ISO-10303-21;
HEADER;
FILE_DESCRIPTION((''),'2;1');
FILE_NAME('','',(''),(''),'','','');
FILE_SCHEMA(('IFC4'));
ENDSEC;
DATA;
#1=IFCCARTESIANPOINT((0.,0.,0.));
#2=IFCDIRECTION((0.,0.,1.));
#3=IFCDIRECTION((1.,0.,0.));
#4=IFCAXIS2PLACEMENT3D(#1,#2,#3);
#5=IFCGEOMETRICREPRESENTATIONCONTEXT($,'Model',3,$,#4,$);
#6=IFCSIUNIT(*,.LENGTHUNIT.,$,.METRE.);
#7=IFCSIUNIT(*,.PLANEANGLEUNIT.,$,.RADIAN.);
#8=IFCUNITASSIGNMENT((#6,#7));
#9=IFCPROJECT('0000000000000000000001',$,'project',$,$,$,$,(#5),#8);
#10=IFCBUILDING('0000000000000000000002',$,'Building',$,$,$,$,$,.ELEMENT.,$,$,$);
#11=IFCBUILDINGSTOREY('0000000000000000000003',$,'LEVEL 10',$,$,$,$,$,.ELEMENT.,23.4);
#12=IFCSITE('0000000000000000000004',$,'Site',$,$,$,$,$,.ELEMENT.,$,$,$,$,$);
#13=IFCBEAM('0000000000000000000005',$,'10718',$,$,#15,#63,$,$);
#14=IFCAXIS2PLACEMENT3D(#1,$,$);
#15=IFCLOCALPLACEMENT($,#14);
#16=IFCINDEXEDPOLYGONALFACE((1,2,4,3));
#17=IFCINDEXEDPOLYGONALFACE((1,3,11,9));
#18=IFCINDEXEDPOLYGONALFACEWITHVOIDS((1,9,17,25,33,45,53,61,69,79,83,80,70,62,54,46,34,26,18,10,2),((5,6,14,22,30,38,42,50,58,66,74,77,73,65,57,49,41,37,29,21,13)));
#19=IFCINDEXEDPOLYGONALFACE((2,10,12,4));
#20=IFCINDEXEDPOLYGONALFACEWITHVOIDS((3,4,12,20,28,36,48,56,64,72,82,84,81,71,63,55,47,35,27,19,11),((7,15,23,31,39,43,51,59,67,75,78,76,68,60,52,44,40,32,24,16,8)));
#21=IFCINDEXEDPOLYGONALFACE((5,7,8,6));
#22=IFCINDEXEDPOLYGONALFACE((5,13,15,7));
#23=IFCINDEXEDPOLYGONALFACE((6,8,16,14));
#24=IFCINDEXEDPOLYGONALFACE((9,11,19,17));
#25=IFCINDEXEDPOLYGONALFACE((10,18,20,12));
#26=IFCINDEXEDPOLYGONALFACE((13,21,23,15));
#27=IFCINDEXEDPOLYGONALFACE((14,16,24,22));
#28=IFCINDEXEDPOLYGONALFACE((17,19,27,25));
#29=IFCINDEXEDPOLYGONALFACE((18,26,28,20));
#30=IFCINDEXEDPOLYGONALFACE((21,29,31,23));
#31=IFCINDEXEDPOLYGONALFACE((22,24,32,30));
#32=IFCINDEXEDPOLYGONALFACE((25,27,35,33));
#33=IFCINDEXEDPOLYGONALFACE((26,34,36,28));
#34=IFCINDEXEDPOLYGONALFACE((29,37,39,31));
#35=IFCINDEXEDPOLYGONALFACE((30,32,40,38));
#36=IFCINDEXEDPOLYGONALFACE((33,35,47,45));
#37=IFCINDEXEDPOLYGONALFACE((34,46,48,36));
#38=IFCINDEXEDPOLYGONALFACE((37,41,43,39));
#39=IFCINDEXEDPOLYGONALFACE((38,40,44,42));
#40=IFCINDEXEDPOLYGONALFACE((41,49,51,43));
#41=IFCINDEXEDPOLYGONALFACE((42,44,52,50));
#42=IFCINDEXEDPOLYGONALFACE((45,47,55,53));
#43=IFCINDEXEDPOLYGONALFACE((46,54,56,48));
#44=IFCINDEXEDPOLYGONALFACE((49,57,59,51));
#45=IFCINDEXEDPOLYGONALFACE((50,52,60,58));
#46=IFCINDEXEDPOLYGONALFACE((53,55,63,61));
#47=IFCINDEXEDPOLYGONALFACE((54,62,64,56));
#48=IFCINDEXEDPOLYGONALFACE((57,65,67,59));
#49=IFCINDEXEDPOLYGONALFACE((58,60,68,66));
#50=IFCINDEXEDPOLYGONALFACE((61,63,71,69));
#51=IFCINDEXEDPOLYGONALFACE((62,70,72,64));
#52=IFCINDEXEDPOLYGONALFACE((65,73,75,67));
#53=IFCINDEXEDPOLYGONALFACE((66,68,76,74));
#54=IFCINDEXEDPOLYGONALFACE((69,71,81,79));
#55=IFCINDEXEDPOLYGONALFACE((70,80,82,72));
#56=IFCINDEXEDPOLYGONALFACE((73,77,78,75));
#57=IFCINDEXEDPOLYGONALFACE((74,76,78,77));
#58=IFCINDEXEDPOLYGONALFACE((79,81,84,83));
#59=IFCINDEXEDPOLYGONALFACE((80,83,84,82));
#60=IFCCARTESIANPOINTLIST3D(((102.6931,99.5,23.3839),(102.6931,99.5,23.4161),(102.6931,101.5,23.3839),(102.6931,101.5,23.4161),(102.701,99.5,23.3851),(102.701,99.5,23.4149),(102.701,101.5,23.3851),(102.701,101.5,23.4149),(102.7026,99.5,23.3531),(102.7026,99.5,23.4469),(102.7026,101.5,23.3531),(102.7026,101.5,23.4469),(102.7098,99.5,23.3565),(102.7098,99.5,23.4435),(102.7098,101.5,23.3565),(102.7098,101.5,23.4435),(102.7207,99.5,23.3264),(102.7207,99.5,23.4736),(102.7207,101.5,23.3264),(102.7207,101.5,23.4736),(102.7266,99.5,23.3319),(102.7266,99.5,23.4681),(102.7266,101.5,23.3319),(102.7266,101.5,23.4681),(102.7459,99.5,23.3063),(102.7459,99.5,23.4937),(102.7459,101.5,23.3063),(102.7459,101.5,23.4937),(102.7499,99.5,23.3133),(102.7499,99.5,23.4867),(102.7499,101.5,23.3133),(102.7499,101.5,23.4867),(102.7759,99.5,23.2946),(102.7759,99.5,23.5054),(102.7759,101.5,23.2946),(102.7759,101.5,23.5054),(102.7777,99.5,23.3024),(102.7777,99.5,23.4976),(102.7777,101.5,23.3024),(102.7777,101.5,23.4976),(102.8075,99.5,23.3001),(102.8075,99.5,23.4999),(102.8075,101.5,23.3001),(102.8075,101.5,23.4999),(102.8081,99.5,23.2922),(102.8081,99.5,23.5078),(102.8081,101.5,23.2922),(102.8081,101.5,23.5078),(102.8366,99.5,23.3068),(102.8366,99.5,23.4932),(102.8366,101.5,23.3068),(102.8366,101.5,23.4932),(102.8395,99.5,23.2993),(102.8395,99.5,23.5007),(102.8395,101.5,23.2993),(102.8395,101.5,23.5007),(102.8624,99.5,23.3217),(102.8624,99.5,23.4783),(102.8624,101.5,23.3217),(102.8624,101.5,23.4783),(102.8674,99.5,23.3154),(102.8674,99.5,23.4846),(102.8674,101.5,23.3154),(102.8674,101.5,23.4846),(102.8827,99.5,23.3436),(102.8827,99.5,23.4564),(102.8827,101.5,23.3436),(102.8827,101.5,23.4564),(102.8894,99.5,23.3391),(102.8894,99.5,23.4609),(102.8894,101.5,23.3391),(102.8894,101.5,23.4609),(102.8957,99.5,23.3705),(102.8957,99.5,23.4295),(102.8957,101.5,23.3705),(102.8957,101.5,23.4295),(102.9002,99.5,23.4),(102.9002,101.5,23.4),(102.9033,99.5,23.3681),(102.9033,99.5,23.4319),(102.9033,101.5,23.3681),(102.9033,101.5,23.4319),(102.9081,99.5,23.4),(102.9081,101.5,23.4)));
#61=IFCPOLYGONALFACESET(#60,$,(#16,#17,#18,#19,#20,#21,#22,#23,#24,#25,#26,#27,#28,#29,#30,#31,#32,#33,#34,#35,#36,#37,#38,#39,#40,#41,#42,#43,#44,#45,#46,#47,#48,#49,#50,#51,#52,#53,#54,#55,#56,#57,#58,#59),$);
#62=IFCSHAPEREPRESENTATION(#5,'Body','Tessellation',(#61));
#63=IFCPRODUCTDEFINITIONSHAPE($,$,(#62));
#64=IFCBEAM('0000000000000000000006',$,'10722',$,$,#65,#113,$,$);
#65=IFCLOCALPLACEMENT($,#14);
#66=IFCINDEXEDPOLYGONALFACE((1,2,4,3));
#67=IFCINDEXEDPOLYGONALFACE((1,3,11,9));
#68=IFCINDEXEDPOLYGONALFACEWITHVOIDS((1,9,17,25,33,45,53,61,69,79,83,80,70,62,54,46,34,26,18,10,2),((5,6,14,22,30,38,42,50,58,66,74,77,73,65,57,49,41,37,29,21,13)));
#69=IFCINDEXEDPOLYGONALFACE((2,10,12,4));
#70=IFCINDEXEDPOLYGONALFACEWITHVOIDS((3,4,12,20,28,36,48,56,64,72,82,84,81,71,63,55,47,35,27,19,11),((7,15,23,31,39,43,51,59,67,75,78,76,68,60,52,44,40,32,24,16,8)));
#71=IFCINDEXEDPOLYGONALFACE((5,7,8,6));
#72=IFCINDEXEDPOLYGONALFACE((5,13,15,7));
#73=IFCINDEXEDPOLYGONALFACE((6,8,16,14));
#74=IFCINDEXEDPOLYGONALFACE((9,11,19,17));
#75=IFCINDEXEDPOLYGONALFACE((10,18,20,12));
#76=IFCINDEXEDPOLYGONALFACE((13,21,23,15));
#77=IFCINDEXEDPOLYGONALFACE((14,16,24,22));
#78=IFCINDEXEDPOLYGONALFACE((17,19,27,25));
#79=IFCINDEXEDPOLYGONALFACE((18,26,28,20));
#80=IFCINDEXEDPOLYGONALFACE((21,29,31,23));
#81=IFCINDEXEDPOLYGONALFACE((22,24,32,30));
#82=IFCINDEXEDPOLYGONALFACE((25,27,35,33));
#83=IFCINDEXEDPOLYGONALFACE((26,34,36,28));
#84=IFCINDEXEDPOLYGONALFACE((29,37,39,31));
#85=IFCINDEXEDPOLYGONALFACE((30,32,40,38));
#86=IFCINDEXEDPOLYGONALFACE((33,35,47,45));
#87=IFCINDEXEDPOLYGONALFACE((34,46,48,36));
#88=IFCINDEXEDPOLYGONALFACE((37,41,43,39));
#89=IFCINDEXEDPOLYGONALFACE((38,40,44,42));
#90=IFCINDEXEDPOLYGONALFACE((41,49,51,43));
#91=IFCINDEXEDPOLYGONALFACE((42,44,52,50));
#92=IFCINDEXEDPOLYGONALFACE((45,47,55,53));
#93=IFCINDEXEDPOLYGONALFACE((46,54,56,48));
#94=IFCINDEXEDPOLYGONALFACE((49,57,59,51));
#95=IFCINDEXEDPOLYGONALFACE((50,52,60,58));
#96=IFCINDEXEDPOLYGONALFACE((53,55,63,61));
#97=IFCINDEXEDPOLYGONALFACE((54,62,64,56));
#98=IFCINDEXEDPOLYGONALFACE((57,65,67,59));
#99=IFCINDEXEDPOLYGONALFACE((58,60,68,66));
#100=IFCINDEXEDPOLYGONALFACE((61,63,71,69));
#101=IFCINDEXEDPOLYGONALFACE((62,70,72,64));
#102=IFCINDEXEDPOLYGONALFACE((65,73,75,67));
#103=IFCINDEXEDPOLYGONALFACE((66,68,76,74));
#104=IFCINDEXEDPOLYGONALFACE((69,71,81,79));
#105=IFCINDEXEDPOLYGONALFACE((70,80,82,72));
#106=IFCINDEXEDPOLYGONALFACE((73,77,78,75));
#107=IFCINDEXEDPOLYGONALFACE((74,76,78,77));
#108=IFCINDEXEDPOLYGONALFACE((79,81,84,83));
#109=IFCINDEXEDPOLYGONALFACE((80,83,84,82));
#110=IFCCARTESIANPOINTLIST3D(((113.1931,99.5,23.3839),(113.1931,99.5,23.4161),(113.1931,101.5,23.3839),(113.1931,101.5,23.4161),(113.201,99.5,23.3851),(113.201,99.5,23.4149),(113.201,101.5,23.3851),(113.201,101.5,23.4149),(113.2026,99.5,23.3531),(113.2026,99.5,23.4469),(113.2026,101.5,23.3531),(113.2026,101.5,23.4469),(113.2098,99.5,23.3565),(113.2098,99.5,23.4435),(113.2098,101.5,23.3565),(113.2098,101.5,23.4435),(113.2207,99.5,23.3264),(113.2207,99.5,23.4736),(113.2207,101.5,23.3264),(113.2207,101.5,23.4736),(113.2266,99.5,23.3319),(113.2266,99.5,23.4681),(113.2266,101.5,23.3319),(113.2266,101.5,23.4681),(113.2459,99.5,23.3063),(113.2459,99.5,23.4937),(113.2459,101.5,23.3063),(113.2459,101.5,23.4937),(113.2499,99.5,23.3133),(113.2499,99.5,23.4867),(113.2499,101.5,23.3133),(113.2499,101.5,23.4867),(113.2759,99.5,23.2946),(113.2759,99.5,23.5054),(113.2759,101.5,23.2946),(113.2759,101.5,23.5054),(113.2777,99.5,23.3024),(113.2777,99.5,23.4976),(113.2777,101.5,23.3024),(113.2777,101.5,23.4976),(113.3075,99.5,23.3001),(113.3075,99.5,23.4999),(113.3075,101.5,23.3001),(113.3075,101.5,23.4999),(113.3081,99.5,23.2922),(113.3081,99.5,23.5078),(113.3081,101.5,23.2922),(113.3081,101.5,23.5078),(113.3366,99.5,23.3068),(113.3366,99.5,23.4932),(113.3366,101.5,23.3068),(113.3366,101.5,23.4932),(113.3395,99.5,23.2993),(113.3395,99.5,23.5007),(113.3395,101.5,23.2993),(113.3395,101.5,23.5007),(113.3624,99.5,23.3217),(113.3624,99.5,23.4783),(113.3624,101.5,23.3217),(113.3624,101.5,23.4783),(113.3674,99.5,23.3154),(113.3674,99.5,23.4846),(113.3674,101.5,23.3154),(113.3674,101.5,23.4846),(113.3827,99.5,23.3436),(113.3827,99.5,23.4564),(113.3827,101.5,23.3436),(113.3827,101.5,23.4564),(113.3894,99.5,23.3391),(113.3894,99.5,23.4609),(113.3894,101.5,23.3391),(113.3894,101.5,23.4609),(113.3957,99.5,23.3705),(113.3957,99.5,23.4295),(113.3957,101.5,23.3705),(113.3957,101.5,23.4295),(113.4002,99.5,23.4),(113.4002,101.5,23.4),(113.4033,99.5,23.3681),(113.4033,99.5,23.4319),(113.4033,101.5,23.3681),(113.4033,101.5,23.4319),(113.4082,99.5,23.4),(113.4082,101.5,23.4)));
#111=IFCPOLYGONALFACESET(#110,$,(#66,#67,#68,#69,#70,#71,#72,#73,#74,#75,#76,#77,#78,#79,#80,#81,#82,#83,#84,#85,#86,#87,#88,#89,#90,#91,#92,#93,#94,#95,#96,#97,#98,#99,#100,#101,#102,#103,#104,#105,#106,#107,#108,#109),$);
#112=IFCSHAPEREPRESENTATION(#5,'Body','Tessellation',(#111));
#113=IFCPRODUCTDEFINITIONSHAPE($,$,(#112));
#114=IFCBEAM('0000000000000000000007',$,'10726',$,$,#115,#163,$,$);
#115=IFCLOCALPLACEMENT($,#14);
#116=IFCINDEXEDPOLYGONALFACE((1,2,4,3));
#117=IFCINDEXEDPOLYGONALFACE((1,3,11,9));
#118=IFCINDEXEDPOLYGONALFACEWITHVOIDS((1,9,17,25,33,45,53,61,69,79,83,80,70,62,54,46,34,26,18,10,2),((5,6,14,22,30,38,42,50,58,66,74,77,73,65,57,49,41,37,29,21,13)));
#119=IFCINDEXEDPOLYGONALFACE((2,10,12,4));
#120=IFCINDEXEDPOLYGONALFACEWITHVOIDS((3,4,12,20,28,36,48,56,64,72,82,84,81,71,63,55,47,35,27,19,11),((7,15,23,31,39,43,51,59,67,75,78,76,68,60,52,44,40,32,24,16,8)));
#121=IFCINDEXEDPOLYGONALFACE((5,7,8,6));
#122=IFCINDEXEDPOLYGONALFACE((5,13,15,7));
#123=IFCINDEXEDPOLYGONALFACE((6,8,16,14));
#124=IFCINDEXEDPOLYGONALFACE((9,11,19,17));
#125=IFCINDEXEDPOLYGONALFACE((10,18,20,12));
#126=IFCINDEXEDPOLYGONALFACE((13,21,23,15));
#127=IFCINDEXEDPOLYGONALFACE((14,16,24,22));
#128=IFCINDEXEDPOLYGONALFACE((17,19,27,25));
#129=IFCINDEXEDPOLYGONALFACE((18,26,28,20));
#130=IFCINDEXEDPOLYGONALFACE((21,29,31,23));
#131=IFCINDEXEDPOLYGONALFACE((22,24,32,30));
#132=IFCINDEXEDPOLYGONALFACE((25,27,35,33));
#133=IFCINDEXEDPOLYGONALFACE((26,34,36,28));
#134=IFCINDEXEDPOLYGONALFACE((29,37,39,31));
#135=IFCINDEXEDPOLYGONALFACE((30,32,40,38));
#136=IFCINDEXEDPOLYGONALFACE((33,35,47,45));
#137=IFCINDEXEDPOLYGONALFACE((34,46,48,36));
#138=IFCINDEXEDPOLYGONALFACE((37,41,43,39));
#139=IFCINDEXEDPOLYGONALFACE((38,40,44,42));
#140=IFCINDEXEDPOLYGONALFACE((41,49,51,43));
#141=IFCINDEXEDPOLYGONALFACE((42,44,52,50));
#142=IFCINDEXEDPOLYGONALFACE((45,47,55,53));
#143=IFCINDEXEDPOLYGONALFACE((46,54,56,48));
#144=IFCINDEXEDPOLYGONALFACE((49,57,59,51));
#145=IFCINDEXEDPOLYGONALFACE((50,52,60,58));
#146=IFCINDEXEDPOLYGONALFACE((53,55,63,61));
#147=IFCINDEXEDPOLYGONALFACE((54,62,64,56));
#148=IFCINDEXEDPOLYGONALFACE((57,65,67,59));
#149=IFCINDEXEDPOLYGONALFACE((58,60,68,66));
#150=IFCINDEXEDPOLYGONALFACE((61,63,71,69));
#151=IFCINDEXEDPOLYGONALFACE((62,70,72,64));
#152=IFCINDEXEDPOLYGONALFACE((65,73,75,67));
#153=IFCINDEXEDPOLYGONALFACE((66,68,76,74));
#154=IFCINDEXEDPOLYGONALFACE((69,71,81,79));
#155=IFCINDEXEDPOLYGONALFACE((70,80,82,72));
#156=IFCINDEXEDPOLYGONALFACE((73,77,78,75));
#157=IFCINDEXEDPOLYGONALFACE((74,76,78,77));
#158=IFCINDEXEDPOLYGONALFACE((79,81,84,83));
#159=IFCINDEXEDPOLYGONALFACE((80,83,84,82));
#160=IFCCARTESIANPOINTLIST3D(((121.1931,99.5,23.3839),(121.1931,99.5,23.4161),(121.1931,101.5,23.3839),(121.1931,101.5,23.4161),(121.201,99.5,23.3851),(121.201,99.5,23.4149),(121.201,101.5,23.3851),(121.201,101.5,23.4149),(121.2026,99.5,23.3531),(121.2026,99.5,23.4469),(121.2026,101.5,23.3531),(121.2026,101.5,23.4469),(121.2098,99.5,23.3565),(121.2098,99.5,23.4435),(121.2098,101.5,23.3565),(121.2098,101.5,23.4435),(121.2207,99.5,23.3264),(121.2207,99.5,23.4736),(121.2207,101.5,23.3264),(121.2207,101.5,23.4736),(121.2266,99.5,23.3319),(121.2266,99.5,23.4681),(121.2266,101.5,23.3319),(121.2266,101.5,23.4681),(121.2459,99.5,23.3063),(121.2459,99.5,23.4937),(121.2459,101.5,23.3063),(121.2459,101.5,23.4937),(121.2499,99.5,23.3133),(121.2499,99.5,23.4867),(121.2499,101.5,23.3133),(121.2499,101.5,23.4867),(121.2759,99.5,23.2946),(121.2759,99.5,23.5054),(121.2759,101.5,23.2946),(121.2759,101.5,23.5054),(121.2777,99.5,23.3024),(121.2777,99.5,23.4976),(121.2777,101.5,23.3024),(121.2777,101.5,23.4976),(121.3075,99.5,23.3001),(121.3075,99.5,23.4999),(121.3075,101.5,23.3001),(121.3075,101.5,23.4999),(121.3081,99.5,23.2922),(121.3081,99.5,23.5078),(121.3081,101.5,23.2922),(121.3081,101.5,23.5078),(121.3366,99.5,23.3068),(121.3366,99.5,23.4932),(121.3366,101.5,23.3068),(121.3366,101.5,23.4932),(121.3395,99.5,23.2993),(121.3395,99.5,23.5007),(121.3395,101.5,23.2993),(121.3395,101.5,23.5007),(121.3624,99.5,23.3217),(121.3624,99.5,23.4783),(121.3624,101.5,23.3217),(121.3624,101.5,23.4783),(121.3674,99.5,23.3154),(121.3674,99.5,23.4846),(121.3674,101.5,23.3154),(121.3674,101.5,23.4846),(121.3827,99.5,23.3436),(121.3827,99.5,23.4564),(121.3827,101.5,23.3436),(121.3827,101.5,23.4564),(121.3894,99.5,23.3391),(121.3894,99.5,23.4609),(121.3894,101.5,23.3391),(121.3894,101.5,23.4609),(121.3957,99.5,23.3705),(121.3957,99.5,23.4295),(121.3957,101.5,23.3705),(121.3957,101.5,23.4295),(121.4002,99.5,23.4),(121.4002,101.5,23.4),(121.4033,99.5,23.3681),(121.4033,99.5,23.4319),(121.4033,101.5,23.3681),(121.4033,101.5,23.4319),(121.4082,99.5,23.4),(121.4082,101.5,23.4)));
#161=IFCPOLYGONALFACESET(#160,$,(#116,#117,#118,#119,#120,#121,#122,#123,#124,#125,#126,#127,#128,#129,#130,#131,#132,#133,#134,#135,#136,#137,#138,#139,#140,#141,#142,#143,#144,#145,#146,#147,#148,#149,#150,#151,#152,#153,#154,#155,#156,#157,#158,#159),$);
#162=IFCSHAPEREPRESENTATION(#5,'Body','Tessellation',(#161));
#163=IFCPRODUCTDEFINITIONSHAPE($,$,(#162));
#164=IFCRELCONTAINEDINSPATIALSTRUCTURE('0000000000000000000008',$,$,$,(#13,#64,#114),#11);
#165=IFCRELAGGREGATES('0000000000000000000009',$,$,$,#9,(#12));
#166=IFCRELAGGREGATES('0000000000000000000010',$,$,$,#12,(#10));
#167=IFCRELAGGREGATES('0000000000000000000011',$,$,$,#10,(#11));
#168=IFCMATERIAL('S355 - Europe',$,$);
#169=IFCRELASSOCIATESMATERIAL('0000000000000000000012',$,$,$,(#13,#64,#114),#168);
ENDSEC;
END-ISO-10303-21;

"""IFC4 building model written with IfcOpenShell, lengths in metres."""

from ifc_helpers import new_model, si_unit, frame, origin_with_axes, origin_2d_with_axis, place, context, project, spatial, hollow_circle, extrude, material, material_profile, profile_set, profile_usage, element, save


model = new_model("IFC4")

# Units and contexts
model_context = context("Model", 3, world=origin_with_axes())
ifc_project = project(units=[si_unit("LENGTHUNIT", "METRE"), si_unit("PLANEANGLEUNIT", "RADIAN")], contexts=[model_context])

# Site, building, storey
site = spatial("IfcSite", under=ifc_project, Name="Site", CompositionType="ELEMENT")
building = spatial("IfcBuilding", under=site, Name="Building", CompositionType="ELEMENT")
storey = spatial("IfcBuildingStorey", under=building, Name="LEVEL 10", CompositionType="ELEMENT", Elevation=23.4)

# Shared definitions
ifc_material = material(Name="S355 - Europe")

# Beams
ifc_material_profile_1 = material_profile(ifc_material, hollow_circle(Radius=0.1081, WallThickness=0.008, at=origin_2d_with_axis()))
ifc_profile_set_1 = profile_set([ifc_material_profile_1])
ifc_profile_usage_1 = profile_usage(ifc_profile_set_1, cardinal=10)
beam_1_placement = place(None, frame((102.8, 101.5, 23.4), z_axis=(0.0, -1.0, 0.0), x_axis=(1.0, 0.0, 0.0)))
element("IfcBeam", 1, at=beam_1_placement, inside=storey, material=ifc_profile_usage_1, Name="10718", context=model_context, shape_type="SweptSolid", body=[
    extrude(hollow_circle(Radius=0.1081, WallThickness=0.008, at=origin_2d_with_axis()), origin_with_axes(), (0.0, 0.0, 1.0), 2.0),
])
ifc_material_profile_2 = material_profile(ifc_material, hollow_circle(Radius=0.1081, WallThickness=0.008, at=origin_2d_with_axis()))
ifc_profile_set_2 = profile_set([ifc_material_profile_2])
ifc_profile_usage_2 = profile_usage(ifc_profile_set_2, cardinal=10)
beam_2_placement = place(None, frame((113.3, 101.5, 23.4), z_axis=(0.0, -1.0, 0.0), x_axis=(1.0, 0.0, 0.0)))
element("IfcBeam", 2, at=beam_2_placement, inside=storey, material=ifc_profile_usage_2, Name="10722", context=model_context, shape_type="SweptSolid", body=[
    extrude(hollow_circle(Radius=0.1081, WallThickness=0.008, at=origin_2d_with_axis()), origin_with_axes(), (0.0, 0.0, 1.0), 2.0),
])
ifc_material_profile_3 = material_profile(ifc_material, hollow_circle(Radius=0.1081, WallThickness=0.008, at=origin_2d_with_axis()))
ifc_profile_set_3 = profile_set([ifc_material_profile_3])
ifc_profile_usage_3 = profile_usage(ifc_profile_set_3, cardinal=10)
beam_3_placement = place(None, frame((121.3, 101.5, 23.4), z_axis=(0.0, -1.0, 0.0), x_axis=(1.0, 0.0, 0.0)))
element("IfcBeam", 3, at=beam_3_placement, inside=storey, material=ifc_profile_usage_3, Name="10726", context=model_context, shape_type="SweptSolid", body=[
    extrude(hollow_circle(Radius=0.1081, WallThickness=0.008, at=origin_2d_with_axis()), origin_with_axes(), (0.0, 0.0, 1.0), 2.0),
])

save(model, "model.ifc")
